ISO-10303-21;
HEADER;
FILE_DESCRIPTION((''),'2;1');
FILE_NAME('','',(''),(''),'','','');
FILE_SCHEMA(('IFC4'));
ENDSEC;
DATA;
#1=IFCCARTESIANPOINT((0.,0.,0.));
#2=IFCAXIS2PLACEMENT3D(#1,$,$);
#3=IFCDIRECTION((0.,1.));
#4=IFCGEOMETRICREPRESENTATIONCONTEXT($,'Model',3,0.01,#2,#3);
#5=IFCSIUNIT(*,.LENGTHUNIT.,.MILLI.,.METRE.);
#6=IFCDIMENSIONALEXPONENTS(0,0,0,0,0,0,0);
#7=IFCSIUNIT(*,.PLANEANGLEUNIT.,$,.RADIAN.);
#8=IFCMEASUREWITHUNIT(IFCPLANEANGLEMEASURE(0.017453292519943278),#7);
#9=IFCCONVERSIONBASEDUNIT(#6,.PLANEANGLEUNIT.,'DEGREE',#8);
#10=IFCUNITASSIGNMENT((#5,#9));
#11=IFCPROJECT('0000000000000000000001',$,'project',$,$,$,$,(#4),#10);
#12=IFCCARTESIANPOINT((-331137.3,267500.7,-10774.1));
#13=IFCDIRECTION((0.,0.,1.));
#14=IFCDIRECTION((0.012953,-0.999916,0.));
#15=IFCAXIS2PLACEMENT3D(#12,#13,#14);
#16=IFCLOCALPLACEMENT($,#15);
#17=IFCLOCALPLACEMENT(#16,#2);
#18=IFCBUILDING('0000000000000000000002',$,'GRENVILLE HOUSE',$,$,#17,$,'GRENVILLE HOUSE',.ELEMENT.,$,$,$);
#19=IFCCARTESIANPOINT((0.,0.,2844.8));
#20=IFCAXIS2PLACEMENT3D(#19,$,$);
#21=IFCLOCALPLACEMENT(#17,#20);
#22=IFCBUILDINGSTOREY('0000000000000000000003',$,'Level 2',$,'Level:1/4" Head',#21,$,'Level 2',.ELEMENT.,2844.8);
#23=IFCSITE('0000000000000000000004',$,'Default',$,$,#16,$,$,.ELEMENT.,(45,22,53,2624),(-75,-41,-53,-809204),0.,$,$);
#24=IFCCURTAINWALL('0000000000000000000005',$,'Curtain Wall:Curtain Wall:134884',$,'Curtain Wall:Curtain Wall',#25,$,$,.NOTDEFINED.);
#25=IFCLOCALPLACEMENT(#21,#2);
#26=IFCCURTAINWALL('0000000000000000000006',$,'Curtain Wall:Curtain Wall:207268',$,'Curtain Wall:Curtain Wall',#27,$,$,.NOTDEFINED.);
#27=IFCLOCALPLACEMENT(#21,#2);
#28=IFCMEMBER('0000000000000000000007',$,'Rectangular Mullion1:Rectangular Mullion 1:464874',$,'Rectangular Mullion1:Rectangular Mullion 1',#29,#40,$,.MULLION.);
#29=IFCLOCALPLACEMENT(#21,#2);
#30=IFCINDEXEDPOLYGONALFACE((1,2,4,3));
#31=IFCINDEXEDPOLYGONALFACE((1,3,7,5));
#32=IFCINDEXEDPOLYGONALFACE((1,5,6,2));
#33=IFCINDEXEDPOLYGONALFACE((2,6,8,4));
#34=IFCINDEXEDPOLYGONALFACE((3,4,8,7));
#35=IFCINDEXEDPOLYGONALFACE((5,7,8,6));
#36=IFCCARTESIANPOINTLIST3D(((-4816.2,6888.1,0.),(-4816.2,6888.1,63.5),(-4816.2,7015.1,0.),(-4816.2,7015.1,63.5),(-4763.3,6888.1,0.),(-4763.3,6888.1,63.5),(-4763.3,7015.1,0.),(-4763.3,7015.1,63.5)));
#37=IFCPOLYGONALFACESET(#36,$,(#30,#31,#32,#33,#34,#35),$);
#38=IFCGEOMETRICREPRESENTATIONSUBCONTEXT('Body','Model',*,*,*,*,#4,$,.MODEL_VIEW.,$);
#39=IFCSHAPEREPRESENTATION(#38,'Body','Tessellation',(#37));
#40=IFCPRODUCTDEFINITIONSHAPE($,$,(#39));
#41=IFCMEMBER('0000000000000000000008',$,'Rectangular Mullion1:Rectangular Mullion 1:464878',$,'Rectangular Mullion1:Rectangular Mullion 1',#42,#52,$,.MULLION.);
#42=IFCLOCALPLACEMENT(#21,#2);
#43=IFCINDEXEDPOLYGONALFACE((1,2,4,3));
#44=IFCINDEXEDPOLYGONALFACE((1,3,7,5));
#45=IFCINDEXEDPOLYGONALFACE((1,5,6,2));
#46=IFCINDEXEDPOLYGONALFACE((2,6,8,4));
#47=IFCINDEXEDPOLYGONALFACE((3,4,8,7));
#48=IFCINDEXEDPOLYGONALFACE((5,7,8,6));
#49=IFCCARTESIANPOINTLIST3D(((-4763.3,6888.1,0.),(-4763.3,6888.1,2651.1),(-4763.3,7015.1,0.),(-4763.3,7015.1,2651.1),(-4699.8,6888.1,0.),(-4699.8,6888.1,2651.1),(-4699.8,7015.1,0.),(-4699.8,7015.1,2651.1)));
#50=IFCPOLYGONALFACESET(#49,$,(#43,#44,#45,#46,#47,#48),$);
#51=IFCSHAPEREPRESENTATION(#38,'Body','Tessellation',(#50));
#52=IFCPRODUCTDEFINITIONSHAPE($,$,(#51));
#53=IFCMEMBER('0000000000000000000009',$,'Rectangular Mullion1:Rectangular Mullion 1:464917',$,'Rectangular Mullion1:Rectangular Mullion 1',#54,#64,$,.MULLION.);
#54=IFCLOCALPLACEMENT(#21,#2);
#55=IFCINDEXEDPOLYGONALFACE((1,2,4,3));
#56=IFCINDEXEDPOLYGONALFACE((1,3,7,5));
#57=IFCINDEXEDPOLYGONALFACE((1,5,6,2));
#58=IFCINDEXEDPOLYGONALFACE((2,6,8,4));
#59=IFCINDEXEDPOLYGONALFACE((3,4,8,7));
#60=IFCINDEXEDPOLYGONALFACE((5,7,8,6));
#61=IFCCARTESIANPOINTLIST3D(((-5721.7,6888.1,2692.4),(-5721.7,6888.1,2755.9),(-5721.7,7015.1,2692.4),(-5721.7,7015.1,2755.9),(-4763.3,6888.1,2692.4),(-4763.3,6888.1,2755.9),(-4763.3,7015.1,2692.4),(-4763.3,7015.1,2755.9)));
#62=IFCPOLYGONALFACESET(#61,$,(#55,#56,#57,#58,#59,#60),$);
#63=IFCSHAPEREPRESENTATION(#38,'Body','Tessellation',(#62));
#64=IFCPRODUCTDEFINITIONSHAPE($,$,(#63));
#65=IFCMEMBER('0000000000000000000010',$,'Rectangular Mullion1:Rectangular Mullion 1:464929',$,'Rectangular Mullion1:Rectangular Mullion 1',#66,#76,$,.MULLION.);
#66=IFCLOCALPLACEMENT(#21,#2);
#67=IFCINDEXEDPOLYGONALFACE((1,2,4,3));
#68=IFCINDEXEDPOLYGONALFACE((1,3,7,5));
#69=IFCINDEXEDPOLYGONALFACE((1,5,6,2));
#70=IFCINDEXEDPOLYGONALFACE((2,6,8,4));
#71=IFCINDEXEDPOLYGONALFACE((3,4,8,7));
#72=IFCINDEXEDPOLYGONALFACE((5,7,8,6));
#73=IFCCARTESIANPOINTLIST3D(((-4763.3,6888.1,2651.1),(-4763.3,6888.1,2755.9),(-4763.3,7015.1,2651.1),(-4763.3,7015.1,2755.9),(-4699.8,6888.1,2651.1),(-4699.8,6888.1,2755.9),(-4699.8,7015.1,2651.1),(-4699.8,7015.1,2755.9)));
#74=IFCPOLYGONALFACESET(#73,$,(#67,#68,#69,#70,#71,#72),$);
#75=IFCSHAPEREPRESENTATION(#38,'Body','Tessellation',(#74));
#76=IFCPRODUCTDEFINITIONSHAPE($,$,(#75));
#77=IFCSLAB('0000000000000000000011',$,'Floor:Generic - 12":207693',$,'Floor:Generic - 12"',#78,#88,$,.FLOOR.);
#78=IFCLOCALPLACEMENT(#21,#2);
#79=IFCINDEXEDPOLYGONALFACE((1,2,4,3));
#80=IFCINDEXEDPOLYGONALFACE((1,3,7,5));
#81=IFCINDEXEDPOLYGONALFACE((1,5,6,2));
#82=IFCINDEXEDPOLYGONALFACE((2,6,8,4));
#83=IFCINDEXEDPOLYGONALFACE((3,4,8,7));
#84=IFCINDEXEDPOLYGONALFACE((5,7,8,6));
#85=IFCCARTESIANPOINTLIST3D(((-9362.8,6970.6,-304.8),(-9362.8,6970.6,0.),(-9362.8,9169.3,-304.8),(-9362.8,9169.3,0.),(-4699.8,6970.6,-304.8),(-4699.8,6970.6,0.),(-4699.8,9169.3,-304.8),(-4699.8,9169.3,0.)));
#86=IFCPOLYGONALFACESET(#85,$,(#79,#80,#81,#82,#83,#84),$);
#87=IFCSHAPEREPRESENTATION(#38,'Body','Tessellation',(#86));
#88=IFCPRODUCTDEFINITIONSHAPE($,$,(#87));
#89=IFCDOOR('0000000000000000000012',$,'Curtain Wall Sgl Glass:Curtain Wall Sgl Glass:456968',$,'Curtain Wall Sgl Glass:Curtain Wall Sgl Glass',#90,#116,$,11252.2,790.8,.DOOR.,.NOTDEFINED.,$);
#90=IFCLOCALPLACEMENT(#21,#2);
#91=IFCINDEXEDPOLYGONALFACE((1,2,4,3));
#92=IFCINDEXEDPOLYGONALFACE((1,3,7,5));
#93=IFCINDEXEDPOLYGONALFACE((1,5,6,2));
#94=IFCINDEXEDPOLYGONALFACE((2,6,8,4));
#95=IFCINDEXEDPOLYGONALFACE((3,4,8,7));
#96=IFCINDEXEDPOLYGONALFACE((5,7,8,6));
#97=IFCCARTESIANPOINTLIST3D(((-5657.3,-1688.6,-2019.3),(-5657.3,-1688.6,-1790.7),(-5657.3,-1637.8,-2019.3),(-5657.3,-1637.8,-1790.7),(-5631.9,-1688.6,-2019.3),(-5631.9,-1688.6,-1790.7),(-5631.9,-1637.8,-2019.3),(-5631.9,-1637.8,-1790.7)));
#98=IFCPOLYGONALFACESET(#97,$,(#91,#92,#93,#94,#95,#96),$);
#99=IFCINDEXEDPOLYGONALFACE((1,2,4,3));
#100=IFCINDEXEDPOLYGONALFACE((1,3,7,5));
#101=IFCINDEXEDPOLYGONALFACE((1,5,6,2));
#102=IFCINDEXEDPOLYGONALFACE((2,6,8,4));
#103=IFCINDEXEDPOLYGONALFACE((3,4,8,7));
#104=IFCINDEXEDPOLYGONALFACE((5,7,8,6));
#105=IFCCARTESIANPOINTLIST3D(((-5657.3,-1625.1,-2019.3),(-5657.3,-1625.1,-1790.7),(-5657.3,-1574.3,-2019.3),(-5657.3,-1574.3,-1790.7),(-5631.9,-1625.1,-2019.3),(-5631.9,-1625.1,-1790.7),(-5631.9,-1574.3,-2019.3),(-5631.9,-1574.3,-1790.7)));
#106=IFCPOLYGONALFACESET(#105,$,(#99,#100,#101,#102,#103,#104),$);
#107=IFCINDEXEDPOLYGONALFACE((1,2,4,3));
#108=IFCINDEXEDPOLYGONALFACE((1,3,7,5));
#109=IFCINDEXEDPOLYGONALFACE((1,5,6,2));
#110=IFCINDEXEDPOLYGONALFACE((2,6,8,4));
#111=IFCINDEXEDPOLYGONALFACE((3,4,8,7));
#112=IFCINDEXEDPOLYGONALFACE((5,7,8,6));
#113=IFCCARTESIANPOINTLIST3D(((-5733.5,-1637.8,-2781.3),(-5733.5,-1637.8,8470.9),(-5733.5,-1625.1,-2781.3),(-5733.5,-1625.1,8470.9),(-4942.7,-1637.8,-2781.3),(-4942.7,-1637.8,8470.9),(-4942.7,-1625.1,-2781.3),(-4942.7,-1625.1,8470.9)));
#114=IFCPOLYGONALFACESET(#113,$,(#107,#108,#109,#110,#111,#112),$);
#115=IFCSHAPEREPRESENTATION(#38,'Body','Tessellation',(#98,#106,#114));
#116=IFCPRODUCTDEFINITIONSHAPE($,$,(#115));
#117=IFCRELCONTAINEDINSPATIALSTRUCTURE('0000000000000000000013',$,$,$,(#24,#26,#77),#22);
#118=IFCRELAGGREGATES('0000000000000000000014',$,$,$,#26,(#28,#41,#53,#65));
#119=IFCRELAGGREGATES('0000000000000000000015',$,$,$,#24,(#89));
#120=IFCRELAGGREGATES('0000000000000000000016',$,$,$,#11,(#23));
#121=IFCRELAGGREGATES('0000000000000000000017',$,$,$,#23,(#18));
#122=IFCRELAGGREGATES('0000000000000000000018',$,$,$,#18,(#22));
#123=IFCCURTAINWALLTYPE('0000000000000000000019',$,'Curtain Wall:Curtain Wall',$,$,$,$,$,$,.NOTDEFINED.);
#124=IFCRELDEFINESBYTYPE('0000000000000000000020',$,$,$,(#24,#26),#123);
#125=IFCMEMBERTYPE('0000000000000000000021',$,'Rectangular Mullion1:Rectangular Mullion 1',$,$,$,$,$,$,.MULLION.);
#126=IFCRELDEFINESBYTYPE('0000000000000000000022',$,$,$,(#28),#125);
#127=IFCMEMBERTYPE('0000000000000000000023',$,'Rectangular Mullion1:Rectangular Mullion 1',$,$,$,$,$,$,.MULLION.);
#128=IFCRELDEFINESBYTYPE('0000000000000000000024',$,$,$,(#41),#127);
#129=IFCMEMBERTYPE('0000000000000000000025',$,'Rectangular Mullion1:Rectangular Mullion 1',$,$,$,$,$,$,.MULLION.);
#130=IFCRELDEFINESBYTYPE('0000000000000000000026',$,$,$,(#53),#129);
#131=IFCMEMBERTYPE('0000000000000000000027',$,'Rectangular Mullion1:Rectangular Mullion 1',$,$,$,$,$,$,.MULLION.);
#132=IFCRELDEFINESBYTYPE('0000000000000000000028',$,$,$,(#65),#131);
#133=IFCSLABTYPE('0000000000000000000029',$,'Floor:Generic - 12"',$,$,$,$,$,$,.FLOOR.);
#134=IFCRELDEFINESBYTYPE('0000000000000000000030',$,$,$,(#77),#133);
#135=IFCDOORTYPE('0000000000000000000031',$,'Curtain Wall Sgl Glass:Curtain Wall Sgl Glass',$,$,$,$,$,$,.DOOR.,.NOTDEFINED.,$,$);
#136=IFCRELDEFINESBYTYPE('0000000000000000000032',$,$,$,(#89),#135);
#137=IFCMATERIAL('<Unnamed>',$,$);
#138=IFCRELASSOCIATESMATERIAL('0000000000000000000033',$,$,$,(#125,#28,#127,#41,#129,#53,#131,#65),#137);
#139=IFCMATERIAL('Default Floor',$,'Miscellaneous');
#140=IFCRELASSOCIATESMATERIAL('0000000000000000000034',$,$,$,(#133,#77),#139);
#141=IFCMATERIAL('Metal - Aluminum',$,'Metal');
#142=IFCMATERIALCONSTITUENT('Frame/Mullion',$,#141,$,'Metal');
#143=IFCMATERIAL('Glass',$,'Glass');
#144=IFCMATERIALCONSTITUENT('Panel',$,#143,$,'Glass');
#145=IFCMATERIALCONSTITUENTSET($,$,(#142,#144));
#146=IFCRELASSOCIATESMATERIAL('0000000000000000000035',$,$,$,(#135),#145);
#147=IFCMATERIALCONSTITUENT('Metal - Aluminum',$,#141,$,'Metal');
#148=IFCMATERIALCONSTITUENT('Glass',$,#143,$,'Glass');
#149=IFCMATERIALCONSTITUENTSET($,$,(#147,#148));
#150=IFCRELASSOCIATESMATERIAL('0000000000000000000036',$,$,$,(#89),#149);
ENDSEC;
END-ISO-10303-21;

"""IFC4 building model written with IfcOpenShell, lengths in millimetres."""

from ifc_helpers import new_model, entity, si_unit, converted_unit, direction, frame, origin, place, context, subcontext, project, spatial, indexed_curve, outline, extrude, source, transform, mapped, material, constituent, constituent_set, type_object, type_shapes, element, aggregate, save


model = new_model("IFC4")

# Units and contexts
model_context = context("Model", 3, precision=0.01, world=origin(), true_north=direction((0.0, 1.0)))
body_context = subcontext(model_context, "Body", "Model", "MODEL_VIEW")
ifc_project = project(units=[si_unit("LENGTHUNIT", "METRE", prefix="MILLI"), converted_unit("PLANEANGLEUNIT", "DEGREE", entity("IfcPlaneAngleMeasure", 0.017453292519943278), si_unit("PLANEANGLEUNIT", "RADIAN"), dimensions=[0, 0, 0, 0, 0, 0, 0])], contexts=[model_context])

# Site, building, storey
site_placement = place(None, frame((-331137.3, 267500.7, -10774.1), z_axis=(0.0, 0.0, 1.0), x_axis=(0.012953, -0.999916, 0.0)))
site = spatial("IfcSite", under=ifc_project, at=site_placement, Name="Default", CompositionType="ELEMENT", RefLatitude=(45, 22, 53, 2624), RefLongitude=(-75, -41, -53, -809204), RefElevation=0.0)
building_placement = place(site_placement, origin())
building = spatial("IfcBuilding", under=site, at=building_placement, Name="GRENVILLE HOUSE", LongName="GRENVILLE HOUSE", CompositionType="ELEMENT")
storey_placement = place(building_placement, frame((0.0, 0.0, 2844.8)))
storey = spatial("IfcBuildingStorey", under=building, at=storey_placement, Name="Level 2", ObjectType="Level:1/4\" Head", LongName="Level 2", CompositionType="ELEMENT", Elevation=2844.8)

# Shared definitions
ifc_material_1 = material(Name="<Unnamed>")

# Curtain walls, members
curtain_wall_type = type_object("IfcCurtainWallType", Name="Curtain Wall:Curtain Wall", PredefinedType="NOTDEFINED")
curtain_wall_1_placement = place(storey_placement, frame((0.0, 0.0, -2844.8)))
curtain_wall_1 = element("IfcCurtainWall", 1, at=curtain_wall_1_placement, inside=storey, type_object=curtain_wall_type, Name="Curtain Wall:Curtain Wall:134884", ObjectType="Curtain Wall:Curtain Wall", PredefinedType="NOTDEFINED")
curtain_wall_2_placement = place(storey_placement, frame((0.0, 0.0, -2844.8)))
curtain_wall_2 = element("IfcCurtainWall", 2, at=curtain_wall_2_placement, inside=storey, type_object=curtain_wall_type, Name="Curtain Wall:Curtain Wall:207268", ObjectType="Curtain Wall:Curtain Wall", PredefinedType="NOTDEFINED")
member_type_1 = type_object("IfcMemberType", Name="Rectangular Mullion1:Rectangular Mullion 1", PredefinedType="MULLION", material=ifc_material_1)
shared_shape_1 = source(origin(), body_context, "Body", "SweptSolid", [
    extrude(outline(indexed_curve([(-31.8, -63.5), (31.8, -63.5), (31.8, 63.5), (-31.8, 63.5), (-31.8, -63.5)], self_intersect=False)), frame((-31.8, 0.0, -52.9), z_axis=(0.0, 0.0, 1.0), x_axis=(-1.0, 0.0, 0.0)), (0.0, 0.0, 1.0), 52.9),
])
type_shapes(member_type_1, [shared_shape_1])
member_1_placement = place(curtain_wall_2_placement, frame((-4763.3, 6951.6, 2844.8), z_axis=(1.0, 0.0, 0.0), x_axis=(0.0, 0.0, -1.0)))
member_1 = element("IfcMember", 3, at=member_1_placement, type_object=member_type_1, material=ifc_material_1, Name="Rectangular Mullion1:Rectangular Mullion 1:464874", ObjectType="Rectangular Mullion1:Rectangular Mullion 1", PredefinedType="MULLION", context=body_context, shape_type="MappedRepresentation", body=[
    mapped(shared_shape_1, transform((0.0, 0.0, 0.0), scale=1.0)),
])
member_type_2 = type_object("IfcMemberType", Name="Rectangular Mullion1:Rectangular Mullion 1", PredefinedType="MULLION", material=ifc_material_1)
shared_shape_2 = source(origin(), body_context, "Body", "SweptSolid", [
    extrude(outline(indexed_curve([(-31.8, -63.5), (31.8, -63.5), (31.8, 63.5), (-31.8, 63.5), (-31.8, -63.5)], self_intersect=False)), frame((-31.8, 0.0, -2651.1), z_axis=(0.0, 0.0, 1.0), x_axis=(-1.0, 0.0, 0.0)), (0.0, 0.0, 1.0), 2651.1),
])
type_shapes(member_type_2, [shared_shape_2])
member_2_placement = place(curtain_wall_2_placement, frame((-4699.8, 6951.6, 5495.9)))
member_2 = element("IfcMember", 4, at=member_2_placement, type_object=member_type_2, material=ifc_material_1, Name="Rectangular Mullion1:Rectangular Mullion 1:464878", ObjectType="Rectangular Mullion1:Rectangular Mullion 1", PredefinedType="MULLION", context=body_context, shape_type="MappedRepresentation", body=[
    mapped(shared_shape_2, transform((0.0, 0.0, 0.0), scale=1.0)),
])
member_type_3 = type_object("IfcMemberType", Name="Rectangular Mullion1:Rectangular Mullion 1", PredefinedType="MULLION", material=ifc_material_1)
shared_shape_3 = source(origin(), body_context, "Body", "SweptSolid", [
    extrude(outline(indexed_curve([(-31.8, -63.5), (31.8, -63.5), (31.8, 63.5), (-31.8, 63.5), (-31.8, -63.5)], self_intersect=False)), frame((-31.8, 0.0, -958.3), z_axis=(0.0, 0.0, 1.0), x_axis=(-1.0, 0.0, 0.0)), (0.0, 0.0, 1.0), 958.3),
])
type_shapes(member_type_3, [shared_shape_3])
member_3_placement = place(curtain_wall_2_placement, frame((-5721.7, 6951.6, 5600.7), z_axis=(-1.0, 0.0, 0.0), x_axis=(0.0, 0.0, 1.0)))
member_3 = element("IfcMember", 5, at=member_3_placement, type_object=member_type_3, material=ifc_material_1, Name="Rectangular Mullion1:Rectangular Mullion 1:464917", ObjectType="Rectangular Mullion1:Rectangular Mullion 1", PredefinedType="MULLION", context=body_context, shape_type="MappedRepresentation", body=[
    mapped(shared_shape_3, transform((0.0, 0.0, 0.0), scale=1.0)),
])
member_type_4 = type_object("IfcMemberType", Name="Rectangular Mullion1:Rectangular Mullion 1", PredefinedType="MULLION", material=ifc_material_1)
shared_shape_4 = source(origin(), body_context, "Body", "SweptSolid", [
    extrude(outline(indexed_curve([(-31.8, -63.5), (31.8, -63.5), (31.8, 63.5), (-31.8, 63.5), (-31.8, -63.5)], self_intersect=False)), frame((-31.8, 0.0, -104.8), z_axis=(0.0, 0.0, 1.0), x_axis=(-1.0, 0.0, 0.0)), (0.0, 0.0, 1.0), 104.8),
])
type_shapes(member_type_4, [shared_shape_4])
member_4_placement = place(curtain_wall_2_placement, frame((-4699.8, 6951.6, 5600.7)))
member_4 = element("IfcMember", 6, at=member_4_placement, type_object=member_type_4, material=ifc_material_1, Name="Rectangular Mullion1:Rectangular Mullion 1:464929", ObjectType="Rectangular Mullion1:Rectangular Mullion 1", PredefinedType="MULLION", context=body_context, shape_type="MappedRepresentation", body=[
    mapped(shared_shape_4, transform((0.0, 0.0, 0.0), scale=1.0)),
])

# Shared definitions
ifc_material_2 = material(Name="Glass", Category="Glass")
aggregate(curtain_wall_2, [member_1, member_2, member_3, member_4])

# Slab
ifc_material_3 = material(Name="Default Floor", Category="Miscellaneous")
slab_type_1 = type_object("IfcSlabType", Name="Floor:Generic - 12\"", PredefinedType="FLOOR", material=ifc_material_3)
slab_1_placement = place(storey_placement, origin())
element("IfcSlab", 7, at=slab_1_placement, inside=storey, type_object=slab_type_1, material=ifc_material_3, Name="Floor:Generic - 12\":207693", ObjectType="Floor:Generic - 12\"", PredefinedType="FLOOR", context=body_context, shape_type="SweptSolid", body=[
    extrude(outline(indexed_curve([(-1099.3, -2331.5), (1099.3, -2331.5), (1099.3, 2331.5), (-1099.3, 2331.5), (-1099.3, -2331.5)], self_intersect=False)), frame((-7031.3, 8070.0, 0.0), z_axis=(0.0, 0.0, -1.0), x_axis=(0.0, 1.0, 0.0)), (0.0, 0.0, 1.0), 304.8),
])

# Door
ifc_material_4 = material(Name="Metal - Aluminum", Category="Metal")
ifc_constituent_1 = constituent(ifc_material_4, Name="Metal - Aluminum", Category="Metal")
ifc_constituent_2 = constituent(ifc_material_2, Name="Glass", Category="Glass")
ifc_constituent_set_1 = constituent_set(constituents=[ifc_constituent_1, ifc_constituent_2])
ifc_constituent_3 = constituent(ifc_material_4, Name="Frame/Mullion", Category="Metal")
ifc_constituent_4 = constituent(ifc_material_2, Name="Panel", Category="Glass")
ifc_constituent_set_2 = constituent_set(constituents=[ifc_constituent_3, ifc_constituent_4])
door_type = type_object("IfcDoorType", Name="Curtain Wall Sgl Glass:Curtain Wall Sgl Glass", OperationType="NOTDEFINED", PredefinedType="DOOR", material=ifc_constituent_set_2)
shared_shape_5 = source(origin(), body_context, "Body", "SweptSolid", [
    extrude(outline(indexed_curve([(-25.4, -12.7), (25.4, -12.7), (25.4, 12.7), (-25.4, 12.7), (-25.4, -12.7)], self_intersect=False)), frame((-306.5, 12.7, 762.0), z_axis=(0.0, 0.0, 1.0), x_axis=(0.0, 1.0, 0.0)), (0.0, 0.0, 1.0), 228.6),
    extrude(outline(indexed_curve([(-25.4, -12.7), (25.4, -12.7), (25.4, 12.7), (-25.4, 12.7), (-25.4, -12.7)], self_intersect=False)), frame((-306.5, 76.2, 762.0), z_axis=(0.0, 0.0, 1.0), x_axis=(0.0, -1.0, 0.0)), (0.0, 0.0, 1.0), 228.6),
    extrude(outline(indexed_curve([(-395.4, -6.4), (395.4, -6.4), (395.4, 6.4), (-395.4, 6.4), (-395.4, -6.4)], self_intersect=False)), frame((0.0, 44.5, 0.0), z_axis=(0.0, 0.0, 1.0), x_axis=(-1.0, 0.0, 0.0)), (0.0, 0.0, 1.0), 11252.2),
])
type_shapes(door_type, [shared_shape_5])
door_placement = place(curtain_wall_1_placement, frame((-5338.1, -1675.9, 63.5)))
door = element("IfcDoor", 8, at=door_placement, type_object=door_type, material=ifc_constituent_set_1, Name="Curtain Wall Sgl Glass:Curtain Wall Sgl Glass:456968", ObjectType="Curtain Wall Sgl Glass:Curtain Wall Sgl Glass", OperationType="NOTDEFINED", OverallHeight=11252.2, OverallWidth=790.8, PredefinedType="DOOR", context=body_context, shape_type="MappedRepresentation", body=[
    mapped(shared_shape_5, transform((0.0, 0.0, 0.0), scale=1.0)),
])
aggregate(curtain_wall_1, [door])

save(model, "model.ifc")
